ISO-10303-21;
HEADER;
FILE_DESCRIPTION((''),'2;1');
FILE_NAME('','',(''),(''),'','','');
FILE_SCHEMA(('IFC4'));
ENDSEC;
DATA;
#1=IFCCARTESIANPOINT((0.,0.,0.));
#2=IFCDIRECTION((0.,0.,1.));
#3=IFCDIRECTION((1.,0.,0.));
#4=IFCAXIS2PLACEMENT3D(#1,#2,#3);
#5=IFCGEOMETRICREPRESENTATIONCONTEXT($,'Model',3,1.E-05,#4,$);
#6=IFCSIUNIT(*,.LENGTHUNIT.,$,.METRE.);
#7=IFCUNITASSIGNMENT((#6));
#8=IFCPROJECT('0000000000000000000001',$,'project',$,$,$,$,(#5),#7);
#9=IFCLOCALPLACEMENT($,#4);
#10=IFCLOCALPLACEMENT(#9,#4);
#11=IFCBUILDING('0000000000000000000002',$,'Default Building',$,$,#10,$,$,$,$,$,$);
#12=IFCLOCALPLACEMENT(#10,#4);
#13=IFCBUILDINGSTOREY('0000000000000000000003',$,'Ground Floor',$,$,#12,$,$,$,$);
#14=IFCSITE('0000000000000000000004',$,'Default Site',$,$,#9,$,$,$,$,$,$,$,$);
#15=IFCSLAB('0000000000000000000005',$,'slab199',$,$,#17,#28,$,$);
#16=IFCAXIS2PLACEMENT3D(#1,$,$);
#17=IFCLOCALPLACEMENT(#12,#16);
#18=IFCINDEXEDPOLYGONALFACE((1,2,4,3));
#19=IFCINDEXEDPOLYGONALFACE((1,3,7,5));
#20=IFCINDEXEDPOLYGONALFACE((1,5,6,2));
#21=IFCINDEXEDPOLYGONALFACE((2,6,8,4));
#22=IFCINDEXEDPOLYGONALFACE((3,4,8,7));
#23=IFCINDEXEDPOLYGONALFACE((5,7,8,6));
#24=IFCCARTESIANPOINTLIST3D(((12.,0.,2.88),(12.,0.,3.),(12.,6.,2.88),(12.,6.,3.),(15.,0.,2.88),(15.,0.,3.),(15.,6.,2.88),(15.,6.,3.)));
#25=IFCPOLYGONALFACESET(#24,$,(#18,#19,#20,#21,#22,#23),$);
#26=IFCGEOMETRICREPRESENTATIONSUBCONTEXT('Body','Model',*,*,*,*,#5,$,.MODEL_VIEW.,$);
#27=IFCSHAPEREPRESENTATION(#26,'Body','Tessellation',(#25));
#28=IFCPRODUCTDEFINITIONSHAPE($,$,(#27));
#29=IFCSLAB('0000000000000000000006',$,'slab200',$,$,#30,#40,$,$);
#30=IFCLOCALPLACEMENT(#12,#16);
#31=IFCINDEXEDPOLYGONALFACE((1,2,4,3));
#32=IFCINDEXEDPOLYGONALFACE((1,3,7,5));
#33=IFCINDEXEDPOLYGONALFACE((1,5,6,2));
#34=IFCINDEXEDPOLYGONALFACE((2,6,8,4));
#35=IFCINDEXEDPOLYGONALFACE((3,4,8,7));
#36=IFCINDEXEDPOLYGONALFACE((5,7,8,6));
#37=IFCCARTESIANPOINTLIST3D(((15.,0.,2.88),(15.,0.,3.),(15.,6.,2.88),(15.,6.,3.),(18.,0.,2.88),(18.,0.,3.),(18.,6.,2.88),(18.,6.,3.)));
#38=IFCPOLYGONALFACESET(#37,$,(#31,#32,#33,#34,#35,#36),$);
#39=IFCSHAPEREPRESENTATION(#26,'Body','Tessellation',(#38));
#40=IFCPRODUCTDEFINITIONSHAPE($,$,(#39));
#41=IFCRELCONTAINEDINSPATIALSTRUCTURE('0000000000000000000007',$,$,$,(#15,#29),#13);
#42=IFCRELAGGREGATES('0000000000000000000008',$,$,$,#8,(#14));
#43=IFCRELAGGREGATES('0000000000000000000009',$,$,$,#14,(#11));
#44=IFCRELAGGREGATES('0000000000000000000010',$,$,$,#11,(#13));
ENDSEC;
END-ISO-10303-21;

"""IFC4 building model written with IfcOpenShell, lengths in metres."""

from ifc_helpers import new_model, si_unit, frame, origin_with_axes, place, context, subcontext, project, spatial, indexed_curve, outline, extrude, element, save


model = new_model("IFC4")

# Units and contexts
model_context = context("Model", 3, precision=1e-05, world=origin_with_axes())
body_context = subcontext(model_context, "Body", "Model", "MODEL_VIEW")
ifc_project = project(units=[si_unit("LENGTHUNIT", "METRE")], contexts=[model_context])

# Site, building, storey
site_placement = place(None, origin_with_axes())
site = spatial("IfcSite", under=ifc_project, at=site_placement, Name="Default Site")
building_placement = place(site_placement, origin_with_axes())
building = spatial("IfcBuilding", under=site, at=building_placement, Name="Default Building")
storey_placement = place(building_placement, origin_with_axes())
storey = spatial("IfcBuildingStorey", under=building, at=storey_placement, Name="Ground Floor")

# Slabs
for number, where, z_axis, x_axis, name in (
    (1, (12.0, 0.0, 2.88), (0.0, 0.0, 1.0), (1.0, 0.0, 0.0), "slab199"),
    (2, (15.0, 0.0, 2.88), (0.0, 0.0, 1.0), (1.0, 0.0, 0.0), "slab200"),
):
    element("IfcSlab", number, at=place(storey_placement, frame(where, z_axis=z_axis, x_axis=x_axis)), inside=storey, Name=name, context=body_context, shape_type="SweptSolid", body=[
        extrude(outline(indexed_curve([(0.0, 0.0), (0.0, 6.0), (3.0, 6.0), (3.0, 0.0), (0.0, 0.0)], self_intersect=False)), origin_with_axes(), (0.0, 0.0, 1.0), 0.12),
    ])

save(model, "model.ifc")
